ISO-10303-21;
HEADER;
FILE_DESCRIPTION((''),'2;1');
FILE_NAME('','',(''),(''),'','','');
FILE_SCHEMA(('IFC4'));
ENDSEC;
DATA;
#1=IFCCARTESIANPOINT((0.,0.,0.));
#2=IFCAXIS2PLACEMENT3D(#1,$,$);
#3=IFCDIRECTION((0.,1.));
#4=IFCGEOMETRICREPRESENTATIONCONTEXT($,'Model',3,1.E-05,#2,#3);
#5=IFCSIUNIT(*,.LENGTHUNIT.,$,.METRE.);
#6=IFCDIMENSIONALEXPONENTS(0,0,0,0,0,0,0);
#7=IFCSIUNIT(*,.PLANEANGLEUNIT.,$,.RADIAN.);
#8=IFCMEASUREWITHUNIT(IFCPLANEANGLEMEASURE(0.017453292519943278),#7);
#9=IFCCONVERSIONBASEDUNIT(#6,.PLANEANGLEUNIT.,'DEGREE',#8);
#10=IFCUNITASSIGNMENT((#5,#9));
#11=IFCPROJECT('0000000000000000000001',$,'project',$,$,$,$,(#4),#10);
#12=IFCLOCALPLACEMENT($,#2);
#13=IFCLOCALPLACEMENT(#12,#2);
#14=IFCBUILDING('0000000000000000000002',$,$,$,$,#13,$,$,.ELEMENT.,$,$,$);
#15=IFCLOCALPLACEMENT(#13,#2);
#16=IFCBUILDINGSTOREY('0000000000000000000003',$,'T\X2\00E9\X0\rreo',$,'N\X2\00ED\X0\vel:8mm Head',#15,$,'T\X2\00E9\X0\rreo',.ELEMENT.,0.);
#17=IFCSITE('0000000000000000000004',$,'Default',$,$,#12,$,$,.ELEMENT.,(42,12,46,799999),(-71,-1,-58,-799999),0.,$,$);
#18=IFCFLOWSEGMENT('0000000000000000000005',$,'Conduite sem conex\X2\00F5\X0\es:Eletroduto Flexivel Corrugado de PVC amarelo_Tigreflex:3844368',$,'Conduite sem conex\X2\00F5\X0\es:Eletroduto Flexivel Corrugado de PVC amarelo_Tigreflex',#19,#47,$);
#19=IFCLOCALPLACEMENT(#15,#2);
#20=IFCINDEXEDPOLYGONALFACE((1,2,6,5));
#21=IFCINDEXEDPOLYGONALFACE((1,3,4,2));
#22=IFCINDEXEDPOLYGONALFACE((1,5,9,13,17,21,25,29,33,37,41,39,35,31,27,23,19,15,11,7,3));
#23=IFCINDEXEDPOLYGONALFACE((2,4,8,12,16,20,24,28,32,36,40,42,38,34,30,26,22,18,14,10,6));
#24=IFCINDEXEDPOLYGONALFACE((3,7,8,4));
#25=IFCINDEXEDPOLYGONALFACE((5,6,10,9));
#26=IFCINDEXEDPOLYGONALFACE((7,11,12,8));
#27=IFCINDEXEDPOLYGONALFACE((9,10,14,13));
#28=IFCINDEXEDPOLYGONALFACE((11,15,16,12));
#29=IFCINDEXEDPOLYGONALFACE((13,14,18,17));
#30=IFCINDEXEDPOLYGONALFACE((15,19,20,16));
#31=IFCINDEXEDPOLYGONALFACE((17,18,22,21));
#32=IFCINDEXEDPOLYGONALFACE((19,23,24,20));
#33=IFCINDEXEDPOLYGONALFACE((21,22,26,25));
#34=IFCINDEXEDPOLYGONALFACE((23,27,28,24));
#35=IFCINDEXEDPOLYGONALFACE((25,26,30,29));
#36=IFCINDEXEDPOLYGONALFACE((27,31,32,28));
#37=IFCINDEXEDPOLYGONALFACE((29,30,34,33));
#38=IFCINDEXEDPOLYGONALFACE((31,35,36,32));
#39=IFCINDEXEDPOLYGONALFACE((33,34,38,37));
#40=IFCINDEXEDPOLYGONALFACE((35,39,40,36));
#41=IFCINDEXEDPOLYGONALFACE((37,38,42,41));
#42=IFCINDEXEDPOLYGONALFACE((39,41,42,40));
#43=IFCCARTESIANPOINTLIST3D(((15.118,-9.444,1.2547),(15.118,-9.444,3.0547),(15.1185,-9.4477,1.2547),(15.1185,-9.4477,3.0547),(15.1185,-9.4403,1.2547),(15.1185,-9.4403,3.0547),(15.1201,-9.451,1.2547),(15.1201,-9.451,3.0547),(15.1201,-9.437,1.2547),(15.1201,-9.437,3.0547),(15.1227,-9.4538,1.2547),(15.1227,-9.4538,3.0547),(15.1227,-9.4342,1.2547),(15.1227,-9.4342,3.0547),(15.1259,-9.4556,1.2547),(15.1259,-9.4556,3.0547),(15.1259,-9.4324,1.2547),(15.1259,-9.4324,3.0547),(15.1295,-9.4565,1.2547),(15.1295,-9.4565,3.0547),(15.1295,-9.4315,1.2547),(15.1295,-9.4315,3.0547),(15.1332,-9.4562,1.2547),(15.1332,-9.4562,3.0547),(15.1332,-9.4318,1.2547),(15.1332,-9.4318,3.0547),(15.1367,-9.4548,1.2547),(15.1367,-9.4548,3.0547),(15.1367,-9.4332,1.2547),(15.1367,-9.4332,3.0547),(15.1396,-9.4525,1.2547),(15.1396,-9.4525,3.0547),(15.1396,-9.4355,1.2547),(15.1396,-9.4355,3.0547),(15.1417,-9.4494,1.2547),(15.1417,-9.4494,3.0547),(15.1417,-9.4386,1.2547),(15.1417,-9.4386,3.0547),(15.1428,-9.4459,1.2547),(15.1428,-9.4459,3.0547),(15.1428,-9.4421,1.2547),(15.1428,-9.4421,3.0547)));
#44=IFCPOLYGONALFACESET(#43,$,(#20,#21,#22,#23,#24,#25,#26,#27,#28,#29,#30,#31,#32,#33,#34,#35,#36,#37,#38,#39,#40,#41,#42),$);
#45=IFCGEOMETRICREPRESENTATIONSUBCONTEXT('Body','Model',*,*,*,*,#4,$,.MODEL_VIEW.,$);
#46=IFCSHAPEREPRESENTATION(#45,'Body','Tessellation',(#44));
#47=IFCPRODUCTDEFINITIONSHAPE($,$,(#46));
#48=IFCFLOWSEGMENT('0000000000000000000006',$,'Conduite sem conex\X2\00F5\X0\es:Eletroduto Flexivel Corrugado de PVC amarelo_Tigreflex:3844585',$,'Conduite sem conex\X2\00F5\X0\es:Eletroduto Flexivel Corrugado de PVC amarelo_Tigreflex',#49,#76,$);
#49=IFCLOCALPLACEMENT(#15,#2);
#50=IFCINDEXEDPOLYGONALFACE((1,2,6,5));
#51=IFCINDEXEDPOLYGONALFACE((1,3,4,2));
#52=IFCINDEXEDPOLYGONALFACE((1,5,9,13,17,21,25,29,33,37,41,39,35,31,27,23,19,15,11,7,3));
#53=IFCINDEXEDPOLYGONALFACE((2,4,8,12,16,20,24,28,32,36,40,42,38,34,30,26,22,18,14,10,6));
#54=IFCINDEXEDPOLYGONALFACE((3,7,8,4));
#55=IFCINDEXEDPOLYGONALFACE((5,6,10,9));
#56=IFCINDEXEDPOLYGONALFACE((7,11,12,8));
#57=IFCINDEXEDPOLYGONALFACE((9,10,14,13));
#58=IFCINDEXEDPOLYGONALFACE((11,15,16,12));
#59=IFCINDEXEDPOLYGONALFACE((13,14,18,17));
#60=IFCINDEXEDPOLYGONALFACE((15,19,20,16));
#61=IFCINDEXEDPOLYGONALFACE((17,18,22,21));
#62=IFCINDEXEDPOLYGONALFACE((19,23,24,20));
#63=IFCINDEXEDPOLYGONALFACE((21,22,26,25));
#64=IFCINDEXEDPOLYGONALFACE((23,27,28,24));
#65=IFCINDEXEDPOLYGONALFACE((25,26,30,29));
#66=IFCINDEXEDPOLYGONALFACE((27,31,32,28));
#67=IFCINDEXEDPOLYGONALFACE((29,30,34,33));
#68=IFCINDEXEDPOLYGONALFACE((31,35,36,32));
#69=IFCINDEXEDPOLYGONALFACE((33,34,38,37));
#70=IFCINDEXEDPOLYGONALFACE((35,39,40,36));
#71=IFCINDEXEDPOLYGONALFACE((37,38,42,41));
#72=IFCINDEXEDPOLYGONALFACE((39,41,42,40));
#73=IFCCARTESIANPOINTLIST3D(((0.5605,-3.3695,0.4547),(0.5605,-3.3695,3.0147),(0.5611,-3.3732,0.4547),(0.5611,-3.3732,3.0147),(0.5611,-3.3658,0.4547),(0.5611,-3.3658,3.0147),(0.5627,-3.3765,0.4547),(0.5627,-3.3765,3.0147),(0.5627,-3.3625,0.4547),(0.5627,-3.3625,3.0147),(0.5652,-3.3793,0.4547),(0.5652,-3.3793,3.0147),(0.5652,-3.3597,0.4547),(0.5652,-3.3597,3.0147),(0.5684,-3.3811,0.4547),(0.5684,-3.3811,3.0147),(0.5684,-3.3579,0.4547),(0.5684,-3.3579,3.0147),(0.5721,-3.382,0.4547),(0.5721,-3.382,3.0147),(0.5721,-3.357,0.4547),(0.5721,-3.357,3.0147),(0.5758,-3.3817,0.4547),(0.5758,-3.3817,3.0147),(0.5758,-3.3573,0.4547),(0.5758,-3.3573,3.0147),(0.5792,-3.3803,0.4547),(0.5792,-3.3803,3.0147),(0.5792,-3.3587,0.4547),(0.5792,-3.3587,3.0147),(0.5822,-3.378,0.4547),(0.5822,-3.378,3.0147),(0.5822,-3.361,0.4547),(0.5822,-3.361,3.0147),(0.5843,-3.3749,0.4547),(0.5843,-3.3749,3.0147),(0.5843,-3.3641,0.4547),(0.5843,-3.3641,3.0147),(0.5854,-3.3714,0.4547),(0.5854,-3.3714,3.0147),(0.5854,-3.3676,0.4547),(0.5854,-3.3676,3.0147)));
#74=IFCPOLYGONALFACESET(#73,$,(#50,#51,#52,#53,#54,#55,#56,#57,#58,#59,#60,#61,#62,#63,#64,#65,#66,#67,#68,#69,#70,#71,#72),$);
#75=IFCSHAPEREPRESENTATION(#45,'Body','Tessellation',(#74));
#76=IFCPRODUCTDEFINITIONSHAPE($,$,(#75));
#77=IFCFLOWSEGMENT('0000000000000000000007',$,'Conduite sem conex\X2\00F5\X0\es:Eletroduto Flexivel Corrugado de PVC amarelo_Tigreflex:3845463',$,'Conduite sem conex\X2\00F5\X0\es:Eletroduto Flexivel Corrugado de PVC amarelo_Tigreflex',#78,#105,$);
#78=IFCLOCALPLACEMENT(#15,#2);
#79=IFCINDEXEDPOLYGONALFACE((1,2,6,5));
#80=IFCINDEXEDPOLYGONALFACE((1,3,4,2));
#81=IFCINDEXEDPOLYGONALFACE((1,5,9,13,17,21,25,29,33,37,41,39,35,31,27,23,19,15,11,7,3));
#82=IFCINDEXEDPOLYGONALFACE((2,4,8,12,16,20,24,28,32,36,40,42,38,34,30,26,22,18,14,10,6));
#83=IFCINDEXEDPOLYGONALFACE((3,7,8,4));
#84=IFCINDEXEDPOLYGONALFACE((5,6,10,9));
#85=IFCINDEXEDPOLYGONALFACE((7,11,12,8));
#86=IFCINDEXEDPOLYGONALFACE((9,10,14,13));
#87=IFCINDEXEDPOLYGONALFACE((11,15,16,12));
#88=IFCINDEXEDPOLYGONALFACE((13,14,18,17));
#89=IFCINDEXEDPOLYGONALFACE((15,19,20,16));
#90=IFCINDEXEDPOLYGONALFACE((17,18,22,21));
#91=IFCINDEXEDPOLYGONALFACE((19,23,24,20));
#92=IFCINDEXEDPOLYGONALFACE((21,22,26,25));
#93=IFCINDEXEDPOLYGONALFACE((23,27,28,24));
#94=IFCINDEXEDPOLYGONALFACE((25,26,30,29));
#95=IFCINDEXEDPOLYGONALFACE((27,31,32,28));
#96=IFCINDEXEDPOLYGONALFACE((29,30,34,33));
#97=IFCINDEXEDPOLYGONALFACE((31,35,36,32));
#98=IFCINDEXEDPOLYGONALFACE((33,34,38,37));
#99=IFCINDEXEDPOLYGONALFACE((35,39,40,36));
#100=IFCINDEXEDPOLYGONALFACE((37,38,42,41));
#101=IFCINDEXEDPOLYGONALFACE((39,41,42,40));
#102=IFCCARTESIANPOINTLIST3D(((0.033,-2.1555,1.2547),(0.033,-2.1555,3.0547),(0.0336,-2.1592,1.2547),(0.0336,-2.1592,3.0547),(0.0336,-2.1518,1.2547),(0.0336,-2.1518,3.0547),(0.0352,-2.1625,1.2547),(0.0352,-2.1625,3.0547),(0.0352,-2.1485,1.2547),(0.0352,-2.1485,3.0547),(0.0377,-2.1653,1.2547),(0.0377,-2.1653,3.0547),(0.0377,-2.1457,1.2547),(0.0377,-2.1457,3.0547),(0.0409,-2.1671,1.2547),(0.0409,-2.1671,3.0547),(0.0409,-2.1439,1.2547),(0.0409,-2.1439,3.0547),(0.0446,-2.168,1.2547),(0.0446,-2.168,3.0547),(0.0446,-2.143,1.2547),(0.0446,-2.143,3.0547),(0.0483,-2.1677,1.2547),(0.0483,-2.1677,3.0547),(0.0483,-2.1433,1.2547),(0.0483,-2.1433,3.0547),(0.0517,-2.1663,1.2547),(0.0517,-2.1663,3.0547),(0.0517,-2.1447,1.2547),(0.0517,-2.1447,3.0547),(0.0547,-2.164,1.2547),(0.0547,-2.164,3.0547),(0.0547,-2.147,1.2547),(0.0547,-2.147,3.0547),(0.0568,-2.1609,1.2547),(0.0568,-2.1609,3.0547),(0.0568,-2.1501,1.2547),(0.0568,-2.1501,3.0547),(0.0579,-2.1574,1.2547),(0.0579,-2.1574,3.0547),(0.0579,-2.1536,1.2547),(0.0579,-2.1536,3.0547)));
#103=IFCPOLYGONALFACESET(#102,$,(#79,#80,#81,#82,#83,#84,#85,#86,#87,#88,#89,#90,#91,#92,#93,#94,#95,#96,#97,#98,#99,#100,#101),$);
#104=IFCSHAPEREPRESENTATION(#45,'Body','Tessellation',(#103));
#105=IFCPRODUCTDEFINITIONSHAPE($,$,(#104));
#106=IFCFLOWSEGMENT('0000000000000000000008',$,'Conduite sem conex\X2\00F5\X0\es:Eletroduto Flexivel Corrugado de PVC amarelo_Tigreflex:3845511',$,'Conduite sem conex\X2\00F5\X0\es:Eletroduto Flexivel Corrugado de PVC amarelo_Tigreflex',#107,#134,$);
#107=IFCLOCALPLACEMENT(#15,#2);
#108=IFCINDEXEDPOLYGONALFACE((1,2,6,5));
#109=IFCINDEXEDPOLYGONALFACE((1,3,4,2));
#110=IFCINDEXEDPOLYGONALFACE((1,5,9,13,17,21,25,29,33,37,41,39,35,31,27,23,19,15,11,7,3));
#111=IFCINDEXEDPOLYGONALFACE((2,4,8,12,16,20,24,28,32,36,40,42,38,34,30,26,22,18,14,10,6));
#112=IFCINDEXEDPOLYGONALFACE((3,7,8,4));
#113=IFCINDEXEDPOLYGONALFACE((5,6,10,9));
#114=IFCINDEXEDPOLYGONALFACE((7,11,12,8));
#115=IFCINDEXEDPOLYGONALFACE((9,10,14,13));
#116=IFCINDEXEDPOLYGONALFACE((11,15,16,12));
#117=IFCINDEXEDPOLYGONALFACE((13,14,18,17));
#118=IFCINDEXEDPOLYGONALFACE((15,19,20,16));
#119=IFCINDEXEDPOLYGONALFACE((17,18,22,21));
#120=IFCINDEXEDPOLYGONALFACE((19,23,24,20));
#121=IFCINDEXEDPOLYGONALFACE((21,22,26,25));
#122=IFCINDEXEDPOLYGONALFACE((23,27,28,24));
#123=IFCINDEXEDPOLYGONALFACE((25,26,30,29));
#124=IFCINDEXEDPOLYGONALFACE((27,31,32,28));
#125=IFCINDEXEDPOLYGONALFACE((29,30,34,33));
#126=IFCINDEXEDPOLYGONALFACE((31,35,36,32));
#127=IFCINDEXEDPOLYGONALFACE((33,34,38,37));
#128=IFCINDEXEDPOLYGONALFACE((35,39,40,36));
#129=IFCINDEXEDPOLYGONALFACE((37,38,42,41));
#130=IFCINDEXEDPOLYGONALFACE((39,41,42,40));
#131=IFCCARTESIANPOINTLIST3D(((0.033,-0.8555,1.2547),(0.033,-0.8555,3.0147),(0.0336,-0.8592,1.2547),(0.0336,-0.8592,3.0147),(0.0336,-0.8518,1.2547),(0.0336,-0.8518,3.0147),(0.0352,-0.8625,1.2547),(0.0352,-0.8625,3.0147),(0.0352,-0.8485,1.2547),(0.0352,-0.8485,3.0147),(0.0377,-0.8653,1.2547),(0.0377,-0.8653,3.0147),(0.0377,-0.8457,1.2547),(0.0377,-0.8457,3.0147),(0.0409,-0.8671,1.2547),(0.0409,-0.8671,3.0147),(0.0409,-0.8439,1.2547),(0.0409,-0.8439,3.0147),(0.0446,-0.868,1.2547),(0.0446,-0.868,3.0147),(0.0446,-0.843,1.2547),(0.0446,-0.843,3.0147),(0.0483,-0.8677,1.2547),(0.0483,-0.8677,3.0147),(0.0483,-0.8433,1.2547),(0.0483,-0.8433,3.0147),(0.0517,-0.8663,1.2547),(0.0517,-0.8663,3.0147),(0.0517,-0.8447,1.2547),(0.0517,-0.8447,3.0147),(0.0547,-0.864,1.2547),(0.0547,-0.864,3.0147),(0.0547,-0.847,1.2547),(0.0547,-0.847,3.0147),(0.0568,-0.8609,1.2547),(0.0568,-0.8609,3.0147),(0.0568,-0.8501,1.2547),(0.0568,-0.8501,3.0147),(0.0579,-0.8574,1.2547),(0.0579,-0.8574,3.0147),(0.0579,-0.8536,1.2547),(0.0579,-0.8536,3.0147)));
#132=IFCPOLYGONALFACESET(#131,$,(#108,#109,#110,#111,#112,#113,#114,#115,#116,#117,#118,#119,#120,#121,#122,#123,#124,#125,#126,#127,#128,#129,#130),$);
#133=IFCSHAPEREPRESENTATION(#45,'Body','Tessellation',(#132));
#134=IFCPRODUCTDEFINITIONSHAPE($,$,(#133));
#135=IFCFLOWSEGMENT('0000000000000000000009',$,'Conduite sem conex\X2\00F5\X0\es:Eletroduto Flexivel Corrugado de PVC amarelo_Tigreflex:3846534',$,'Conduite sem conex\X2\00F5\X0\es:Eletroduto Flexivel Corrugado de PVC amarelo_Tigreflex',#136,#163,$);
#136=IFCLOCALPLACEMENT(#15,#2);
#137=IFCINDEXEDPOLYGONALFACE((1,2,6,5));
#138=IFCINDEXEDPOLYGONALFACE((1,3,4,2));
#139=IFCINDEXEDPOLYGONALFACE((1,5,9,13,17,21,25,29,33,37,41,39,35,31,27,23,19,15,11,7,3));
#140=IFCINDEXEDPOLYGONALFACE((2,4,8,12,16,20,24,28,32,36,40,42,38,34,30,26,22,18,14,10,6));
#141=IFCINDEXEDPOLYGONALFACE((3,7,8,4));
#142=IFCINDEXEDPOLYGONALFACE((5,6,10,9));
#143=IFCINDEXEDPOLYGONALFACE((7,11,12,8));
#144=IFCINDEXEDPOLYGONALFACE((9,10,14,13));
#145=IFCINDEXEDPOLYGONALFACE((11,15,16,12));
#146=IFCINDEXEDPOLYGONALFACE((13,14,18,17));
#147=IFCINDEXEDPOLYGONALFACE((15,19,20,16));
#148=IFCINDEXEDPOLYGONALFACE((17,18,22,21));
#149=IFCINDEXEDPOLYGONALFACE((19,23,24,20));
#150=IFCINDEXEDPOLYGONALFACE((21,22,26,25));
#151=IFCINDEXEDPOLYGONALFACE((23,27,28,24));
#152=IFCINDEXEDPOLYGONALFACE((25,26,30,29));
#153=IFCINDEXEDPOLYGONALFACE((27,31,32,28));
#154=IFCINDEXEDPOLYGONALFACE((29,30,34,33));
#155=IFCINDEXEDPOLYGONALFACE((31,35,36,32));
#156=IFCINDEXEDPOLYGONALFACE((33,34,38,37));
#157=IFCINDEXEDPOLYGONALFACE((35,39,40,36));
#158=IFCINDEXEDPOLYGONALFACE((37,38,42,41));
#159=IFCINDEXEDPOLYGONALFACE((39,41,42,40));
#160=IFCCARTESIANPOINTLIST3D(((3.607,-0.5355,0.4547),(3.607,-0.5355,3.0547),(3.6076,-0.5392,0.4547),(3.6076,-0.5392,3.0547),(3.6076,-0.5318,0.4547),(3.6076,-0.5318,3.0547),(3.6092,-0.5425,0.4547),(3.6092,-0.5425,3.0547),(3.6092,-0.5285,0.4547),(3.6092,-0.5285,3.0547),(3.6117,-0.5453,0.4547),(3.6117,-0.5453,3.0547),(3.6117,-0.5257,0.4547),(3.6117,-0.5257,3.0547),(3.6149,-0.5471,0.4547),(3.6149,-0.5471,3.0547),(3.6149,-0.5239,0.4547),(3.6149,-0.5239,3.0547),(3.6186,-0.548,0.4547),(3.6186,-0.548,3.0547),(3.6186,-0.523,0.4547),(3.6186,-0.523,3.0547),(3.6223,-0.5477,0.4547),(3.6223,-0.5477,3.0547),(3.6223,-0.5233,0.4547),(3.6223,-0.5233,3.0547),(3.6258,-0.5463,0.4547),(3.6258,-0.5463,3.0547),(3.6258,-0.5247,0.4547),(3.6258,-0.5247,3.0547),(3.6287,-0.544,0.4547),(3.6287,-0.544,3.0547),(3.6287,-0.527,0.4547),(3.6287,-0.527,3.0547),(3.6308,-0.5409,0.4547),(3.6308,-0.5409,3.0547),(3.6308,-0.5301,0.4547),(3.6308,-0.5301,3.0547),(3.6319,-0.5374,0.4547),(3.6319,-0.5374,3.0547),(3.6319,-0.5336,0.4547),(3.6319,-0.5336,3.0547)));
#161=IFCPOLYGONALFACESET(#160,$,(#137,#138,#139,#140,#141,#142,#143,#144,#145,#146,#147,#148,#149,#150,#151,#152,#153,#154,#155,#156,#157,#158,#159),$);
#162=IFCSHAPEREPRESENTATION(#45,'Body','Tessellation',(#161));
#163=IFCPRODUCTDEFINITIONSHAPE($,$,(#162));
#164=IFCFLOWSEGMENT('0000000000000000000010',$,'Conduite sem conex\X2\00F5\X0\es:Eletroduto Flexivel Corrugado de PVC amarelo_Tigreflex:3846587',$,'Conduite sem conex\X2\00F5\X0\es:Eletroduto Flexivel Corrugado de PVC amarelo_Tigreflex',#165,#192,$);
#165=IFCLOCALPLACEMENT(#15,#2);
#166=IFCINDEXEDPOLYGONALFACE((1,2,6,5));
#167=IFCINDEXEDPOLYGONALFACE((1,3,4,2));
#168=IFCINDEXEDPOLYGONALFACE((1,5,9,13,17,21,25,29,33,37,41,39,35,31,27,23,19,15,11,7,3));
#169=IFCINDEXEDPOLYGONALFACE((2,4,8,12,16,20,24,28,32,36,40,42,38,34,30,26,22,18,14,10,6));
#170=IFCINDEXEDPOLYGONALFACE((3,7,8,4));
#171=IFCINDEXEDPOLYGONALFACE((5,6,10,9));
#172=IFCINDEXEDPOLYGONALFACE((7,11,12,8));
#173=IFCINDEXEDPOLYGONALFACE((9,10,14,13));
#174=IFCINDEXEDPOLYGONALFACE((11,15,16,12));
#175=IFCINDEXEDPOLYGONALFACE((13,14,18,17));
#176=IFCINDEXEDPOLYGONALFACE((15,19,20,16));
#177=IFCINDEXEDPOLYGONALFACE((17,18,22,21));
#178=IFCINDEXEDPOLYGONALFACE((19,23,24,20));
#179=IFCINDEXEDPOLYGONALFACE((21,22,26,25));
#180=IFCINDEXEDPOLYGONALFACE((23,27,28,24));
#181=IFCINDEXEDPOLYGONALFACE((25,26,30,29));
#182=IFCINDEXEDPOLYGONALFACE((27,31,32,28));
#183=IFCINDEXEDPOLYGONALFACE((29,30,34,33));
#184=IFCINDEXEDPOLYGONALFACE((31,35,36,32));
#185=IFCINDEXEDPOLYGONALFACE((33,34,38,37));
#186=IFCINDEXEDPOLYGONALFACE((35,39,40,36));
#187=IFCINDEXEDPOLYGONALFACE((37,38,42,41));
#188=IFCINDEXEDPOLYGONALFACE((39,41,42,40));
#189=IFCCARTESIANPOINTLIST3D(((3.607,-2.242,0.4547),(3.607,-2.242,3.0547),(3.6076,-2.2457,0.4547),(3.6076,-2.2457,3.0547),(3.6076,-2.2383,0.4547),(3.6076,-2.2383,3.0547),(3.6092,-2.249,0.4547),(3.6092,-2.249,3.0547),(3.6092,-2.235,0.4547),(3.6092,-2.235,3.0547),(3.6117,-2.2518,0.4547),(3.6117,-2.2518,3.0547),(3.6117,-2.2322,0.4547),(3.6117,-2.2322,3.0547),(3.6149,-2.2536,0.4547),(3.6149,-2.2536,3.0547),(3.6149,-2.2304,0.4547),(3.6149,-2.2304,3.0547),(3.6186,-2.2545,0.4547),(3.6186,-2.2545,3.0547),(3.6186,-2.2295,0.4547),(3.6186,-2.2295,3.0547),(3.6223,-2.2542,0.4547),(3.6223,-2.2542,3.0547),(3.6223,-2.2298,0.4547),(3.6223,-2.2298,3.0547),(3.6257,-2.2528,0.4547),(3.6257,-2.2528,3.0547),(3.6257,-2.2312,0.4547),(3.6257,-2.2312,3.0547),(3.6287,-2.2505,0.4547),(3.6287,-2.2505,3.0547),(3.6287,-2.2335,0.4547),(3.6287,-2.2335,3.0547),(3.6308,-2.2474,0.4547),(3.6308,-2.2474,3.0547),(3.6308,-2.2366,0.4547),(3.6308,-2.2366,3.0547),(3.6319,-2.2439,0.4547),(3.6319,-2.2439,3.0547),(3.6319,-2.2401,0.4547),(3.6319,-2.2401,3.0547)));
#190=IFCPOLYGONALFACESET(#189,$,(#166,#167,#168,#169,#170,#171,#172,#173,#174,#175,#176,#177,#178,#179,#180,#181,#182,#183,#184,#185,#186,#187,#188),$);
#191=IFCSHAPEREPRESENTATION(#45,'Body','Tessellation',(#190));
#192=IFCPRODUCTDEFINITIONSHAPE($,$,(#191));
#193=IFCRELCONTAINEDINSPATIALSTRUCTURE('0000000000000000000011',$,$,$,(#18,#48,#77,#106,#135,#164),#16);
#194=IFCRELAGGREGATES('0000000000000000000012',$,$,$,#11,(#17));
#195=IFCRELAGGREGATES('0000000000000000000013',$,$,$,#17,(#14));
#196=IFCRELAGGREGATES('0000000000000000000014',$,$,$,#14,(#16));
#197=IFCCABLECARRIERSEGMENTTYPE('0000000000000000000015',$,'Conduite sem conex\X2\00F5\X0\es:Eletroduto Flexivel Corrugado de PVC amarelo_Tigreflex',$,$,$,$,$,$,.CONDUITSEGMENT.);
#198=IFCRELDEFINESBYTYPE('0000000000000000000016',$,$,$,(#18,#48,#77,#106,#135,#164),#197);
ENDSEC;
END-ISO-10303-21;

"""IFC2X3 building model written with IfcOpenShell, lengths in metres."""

from ifc_helpers import new_model, entity, si_unit, converted_unit, direction, frame, frame_2d, origin, origin_2d_with_axis, place, context, subcontext, project, spatial, circle, extrude, type_object, element, save


model = new_model("IFC2X3")

# Units and contexts
model_context = context("Model", 3, precision=1e-05, world=origin(), true_north=direction((0.0, 1.0)))
body_context = subcontext(model_context, "Body", "Model", "MODEL_VIEW")
ifc_project = project(units=[si_unit("LENGTHUNIT", "METRE"), converted_unit("PLANEANGLEUNIT", "DEGREE", entity("IfcPlaneAngleMeasure", 0.017453292519943278), si_unit("PLANEANGLEUNIT", "RADIAN"), dimensions=[0, 0, 0, 0, 0, 0, 0])], contexts=[model_context])

# Site, building, storey
site_placement = place(None, origin())
site = spatial("IfcSite", under=ifc_project, at=site_placement, Name="Default", CompositionType="ELEMENT", RefLatitude=(42, 12, 46, 799999), RefLongitude=(-71, -1, -58, -799999), RefElevation=0.0)
building_placement = place(site_placement, origin())
building = spatial("IfcBuilding", under=site, at=building_placement, CompositionType="ELEMENT")
storey_placement = place(building_placement, origin())
storey = spatial("IfcBuildingStorey", under=building, at=storey_placement, Name="Térreo", ObjectType="Nível:8mm Head", LongName="Térreo", CompositionType="ELEMENT", Elevation=0.0)

# Flow segments
cable_carrier_segment_type = type_object("IfcCableCarrierSegmentType", Name="Conduite sem conexões:Eletroduto Flexivel Corrugado de PVC amarelo_Tigreflex", PredefinedType="CONDUITSEGMENT")
flow_segment_1_placement = place(storey_placement, origin())
element("IfcFlowSegment", 1, at=flow_segment_1_placement, inside=storey, type_object=cable_carrier_segment_type, Name="Conduite sem conexões:Eletroduto Flexivel Corrugado de PVC amarelo_Tigreflex:3844368", ObjectType="Conduite sem conexões:Eletroduto Flexivel Corrugado de PVC amarelo_Tigreflex", context=body_context, shape_type="SweptSolid", body=[
    extrude(circle(Radius=0.0125, at=frame_2d((0.0, 0.0), x_axis=(1.0, 0.0))), frame((15.1305, -9.444, 1.2547), z_axis=(0.0, 0.0, 1.0), x_axis=(-1.0, 0.0, 0.0)), (0.0, 0.0, 1.0), 1.8),
])
flow_segment_2_placement = place(storey_placement, origin())
element("IfcFlowSegment", 2, at=flow_segment_2_placement, inside=storey, type_object=cable_carrier_segment_type, Name="Conduite sem conexões:Eletroduto Flexivel Corrugado de PVC amarelo_Tigreflex:3844585", ObjectType="Conduite sem conexões:Eletroduto Flexivel Corrugado de PVC amarelo_Tigreflex", context=body_context, shape_type="SweptSolid", body=[
    extrude(circle(Radius=0.0125, at=origin_2d_with_axis()), frame((0.573, -3.3695, 0.4547), z_axis=(0.0, 0.0, 1.0), x_axis=(-1.0, 0.0, 0.0)), (0.0, 0.0, 1.0), 2.56),
])
flow_segment_3_placement = place(storey_placement, origin())
element("IfcFlowSegment", 3, at=flow_segment_3_placement, inside=storey, type_object=cable_carrier_segment_type, Name="Conduite sem conexões:Eletroduto Flexivel Corrugado de PVC amarelo_Tigreflex:3845463", ObjectType="Conduite sem conexões:Eletroduto Flexivel Corrugado de PVC amarelo_Tigreflex", context=body_context, shape_type="SweptSolid", body=[
    extrude(circle(Radius=0.0125, at=frame_2d((0.0, 0.0), x_axis=(1.0, 0.0))), frame((0.0455, -2.1555, 1.2547), z_axis=(0.0, 0.0, 1.0), x_axis=(-1.0, 0.0, 0.0)), (0.0, 0.0, 1.0), 1.8),
])
flow_segment_4_placement = place(storey_placement, origin())
element("IfcFlowSegment", 4, at=flow_segment_4_placement, inside=storey, type_object=cable_carrier_segment_type, Name="Conduite sem conexões:Eletroduto Flexivel Corrugado de PVC amarelo_Tigreflex:3845511", ObjectType="Conduite sem conexões:Eletroduto Flexivel Corrugado de PVC amarelo_Tigreflex", context=body_context, shape_type="SweptSolid", body=[
    extrude(circle(Radius=0.0125, at=frame_2d((0.0, 0.0), x_axis=(1.0, 0.0))), frame((0.0455, -0.8555, 1.2547), z_axis=(0.0, 0.0, 1.0), x_axis=(-1.0, 0.0, 0.0)), (0.0, 0.0, 1.0), 1.76),
])
flow_segment_5_placement = place(storey_placement, origin())
element("IfcFlowSegment", 5, at=flow_segment_5_placement, inside=storey, type_object=cable_carrier_segment_type, Name="Conduite sem conexões:Eletroduto Flexivel Corrugado de PVC amarelo_Tigreflex:3846534", ObjectType="Conduite sem conexões:Eletroduto Flexivel Corrugado de PVC amarelo_Tigreflex", context=body_context, shape_type="SweptSolid", body=[
    extrude(circle(Radius=0.0125, at=frame_2d((0.0, 0.0), x_axis=(1.0, 0.0))), frame((3.6195, -0.5355, 0.4547), z_axis=(0.0, 0.0, 1.0), x_axis=(-1.0, 0.0, 0.0)), (0.0, 0.0, 1.0), 2.6),
])
flow_segment_6_placement = place(storey_placement, origin())
element("IfcFlowSegment", 6, at=flow_segment_6_placement, inside=storey, type_object=cable_carrier_segment_type, Name="Conduite sem conexões:Eletroduto Flexivel Corrugado de PVC amarelo_Tigreflex:3846587", ObjectType="Conduite sem conexões:Eletroduto Flexivel Corrugado de PVC amarelo_Tigreflex", context=body_context, shape_type="SweptSolid", body=[
    extrude(circle(Radius=0.0125, at=frame_2d((0.0, 0.0), x_axis=(1.0, 0.0))), frame((3.6195, -2.242, 0.4547), z_axis=(0.0, 0.0, 1.0), x_axis=(-1.0, 0.0, 0.0)), (0.0, 0.0, 1.0), 2.6),
])

save(model, "model.ifc")
